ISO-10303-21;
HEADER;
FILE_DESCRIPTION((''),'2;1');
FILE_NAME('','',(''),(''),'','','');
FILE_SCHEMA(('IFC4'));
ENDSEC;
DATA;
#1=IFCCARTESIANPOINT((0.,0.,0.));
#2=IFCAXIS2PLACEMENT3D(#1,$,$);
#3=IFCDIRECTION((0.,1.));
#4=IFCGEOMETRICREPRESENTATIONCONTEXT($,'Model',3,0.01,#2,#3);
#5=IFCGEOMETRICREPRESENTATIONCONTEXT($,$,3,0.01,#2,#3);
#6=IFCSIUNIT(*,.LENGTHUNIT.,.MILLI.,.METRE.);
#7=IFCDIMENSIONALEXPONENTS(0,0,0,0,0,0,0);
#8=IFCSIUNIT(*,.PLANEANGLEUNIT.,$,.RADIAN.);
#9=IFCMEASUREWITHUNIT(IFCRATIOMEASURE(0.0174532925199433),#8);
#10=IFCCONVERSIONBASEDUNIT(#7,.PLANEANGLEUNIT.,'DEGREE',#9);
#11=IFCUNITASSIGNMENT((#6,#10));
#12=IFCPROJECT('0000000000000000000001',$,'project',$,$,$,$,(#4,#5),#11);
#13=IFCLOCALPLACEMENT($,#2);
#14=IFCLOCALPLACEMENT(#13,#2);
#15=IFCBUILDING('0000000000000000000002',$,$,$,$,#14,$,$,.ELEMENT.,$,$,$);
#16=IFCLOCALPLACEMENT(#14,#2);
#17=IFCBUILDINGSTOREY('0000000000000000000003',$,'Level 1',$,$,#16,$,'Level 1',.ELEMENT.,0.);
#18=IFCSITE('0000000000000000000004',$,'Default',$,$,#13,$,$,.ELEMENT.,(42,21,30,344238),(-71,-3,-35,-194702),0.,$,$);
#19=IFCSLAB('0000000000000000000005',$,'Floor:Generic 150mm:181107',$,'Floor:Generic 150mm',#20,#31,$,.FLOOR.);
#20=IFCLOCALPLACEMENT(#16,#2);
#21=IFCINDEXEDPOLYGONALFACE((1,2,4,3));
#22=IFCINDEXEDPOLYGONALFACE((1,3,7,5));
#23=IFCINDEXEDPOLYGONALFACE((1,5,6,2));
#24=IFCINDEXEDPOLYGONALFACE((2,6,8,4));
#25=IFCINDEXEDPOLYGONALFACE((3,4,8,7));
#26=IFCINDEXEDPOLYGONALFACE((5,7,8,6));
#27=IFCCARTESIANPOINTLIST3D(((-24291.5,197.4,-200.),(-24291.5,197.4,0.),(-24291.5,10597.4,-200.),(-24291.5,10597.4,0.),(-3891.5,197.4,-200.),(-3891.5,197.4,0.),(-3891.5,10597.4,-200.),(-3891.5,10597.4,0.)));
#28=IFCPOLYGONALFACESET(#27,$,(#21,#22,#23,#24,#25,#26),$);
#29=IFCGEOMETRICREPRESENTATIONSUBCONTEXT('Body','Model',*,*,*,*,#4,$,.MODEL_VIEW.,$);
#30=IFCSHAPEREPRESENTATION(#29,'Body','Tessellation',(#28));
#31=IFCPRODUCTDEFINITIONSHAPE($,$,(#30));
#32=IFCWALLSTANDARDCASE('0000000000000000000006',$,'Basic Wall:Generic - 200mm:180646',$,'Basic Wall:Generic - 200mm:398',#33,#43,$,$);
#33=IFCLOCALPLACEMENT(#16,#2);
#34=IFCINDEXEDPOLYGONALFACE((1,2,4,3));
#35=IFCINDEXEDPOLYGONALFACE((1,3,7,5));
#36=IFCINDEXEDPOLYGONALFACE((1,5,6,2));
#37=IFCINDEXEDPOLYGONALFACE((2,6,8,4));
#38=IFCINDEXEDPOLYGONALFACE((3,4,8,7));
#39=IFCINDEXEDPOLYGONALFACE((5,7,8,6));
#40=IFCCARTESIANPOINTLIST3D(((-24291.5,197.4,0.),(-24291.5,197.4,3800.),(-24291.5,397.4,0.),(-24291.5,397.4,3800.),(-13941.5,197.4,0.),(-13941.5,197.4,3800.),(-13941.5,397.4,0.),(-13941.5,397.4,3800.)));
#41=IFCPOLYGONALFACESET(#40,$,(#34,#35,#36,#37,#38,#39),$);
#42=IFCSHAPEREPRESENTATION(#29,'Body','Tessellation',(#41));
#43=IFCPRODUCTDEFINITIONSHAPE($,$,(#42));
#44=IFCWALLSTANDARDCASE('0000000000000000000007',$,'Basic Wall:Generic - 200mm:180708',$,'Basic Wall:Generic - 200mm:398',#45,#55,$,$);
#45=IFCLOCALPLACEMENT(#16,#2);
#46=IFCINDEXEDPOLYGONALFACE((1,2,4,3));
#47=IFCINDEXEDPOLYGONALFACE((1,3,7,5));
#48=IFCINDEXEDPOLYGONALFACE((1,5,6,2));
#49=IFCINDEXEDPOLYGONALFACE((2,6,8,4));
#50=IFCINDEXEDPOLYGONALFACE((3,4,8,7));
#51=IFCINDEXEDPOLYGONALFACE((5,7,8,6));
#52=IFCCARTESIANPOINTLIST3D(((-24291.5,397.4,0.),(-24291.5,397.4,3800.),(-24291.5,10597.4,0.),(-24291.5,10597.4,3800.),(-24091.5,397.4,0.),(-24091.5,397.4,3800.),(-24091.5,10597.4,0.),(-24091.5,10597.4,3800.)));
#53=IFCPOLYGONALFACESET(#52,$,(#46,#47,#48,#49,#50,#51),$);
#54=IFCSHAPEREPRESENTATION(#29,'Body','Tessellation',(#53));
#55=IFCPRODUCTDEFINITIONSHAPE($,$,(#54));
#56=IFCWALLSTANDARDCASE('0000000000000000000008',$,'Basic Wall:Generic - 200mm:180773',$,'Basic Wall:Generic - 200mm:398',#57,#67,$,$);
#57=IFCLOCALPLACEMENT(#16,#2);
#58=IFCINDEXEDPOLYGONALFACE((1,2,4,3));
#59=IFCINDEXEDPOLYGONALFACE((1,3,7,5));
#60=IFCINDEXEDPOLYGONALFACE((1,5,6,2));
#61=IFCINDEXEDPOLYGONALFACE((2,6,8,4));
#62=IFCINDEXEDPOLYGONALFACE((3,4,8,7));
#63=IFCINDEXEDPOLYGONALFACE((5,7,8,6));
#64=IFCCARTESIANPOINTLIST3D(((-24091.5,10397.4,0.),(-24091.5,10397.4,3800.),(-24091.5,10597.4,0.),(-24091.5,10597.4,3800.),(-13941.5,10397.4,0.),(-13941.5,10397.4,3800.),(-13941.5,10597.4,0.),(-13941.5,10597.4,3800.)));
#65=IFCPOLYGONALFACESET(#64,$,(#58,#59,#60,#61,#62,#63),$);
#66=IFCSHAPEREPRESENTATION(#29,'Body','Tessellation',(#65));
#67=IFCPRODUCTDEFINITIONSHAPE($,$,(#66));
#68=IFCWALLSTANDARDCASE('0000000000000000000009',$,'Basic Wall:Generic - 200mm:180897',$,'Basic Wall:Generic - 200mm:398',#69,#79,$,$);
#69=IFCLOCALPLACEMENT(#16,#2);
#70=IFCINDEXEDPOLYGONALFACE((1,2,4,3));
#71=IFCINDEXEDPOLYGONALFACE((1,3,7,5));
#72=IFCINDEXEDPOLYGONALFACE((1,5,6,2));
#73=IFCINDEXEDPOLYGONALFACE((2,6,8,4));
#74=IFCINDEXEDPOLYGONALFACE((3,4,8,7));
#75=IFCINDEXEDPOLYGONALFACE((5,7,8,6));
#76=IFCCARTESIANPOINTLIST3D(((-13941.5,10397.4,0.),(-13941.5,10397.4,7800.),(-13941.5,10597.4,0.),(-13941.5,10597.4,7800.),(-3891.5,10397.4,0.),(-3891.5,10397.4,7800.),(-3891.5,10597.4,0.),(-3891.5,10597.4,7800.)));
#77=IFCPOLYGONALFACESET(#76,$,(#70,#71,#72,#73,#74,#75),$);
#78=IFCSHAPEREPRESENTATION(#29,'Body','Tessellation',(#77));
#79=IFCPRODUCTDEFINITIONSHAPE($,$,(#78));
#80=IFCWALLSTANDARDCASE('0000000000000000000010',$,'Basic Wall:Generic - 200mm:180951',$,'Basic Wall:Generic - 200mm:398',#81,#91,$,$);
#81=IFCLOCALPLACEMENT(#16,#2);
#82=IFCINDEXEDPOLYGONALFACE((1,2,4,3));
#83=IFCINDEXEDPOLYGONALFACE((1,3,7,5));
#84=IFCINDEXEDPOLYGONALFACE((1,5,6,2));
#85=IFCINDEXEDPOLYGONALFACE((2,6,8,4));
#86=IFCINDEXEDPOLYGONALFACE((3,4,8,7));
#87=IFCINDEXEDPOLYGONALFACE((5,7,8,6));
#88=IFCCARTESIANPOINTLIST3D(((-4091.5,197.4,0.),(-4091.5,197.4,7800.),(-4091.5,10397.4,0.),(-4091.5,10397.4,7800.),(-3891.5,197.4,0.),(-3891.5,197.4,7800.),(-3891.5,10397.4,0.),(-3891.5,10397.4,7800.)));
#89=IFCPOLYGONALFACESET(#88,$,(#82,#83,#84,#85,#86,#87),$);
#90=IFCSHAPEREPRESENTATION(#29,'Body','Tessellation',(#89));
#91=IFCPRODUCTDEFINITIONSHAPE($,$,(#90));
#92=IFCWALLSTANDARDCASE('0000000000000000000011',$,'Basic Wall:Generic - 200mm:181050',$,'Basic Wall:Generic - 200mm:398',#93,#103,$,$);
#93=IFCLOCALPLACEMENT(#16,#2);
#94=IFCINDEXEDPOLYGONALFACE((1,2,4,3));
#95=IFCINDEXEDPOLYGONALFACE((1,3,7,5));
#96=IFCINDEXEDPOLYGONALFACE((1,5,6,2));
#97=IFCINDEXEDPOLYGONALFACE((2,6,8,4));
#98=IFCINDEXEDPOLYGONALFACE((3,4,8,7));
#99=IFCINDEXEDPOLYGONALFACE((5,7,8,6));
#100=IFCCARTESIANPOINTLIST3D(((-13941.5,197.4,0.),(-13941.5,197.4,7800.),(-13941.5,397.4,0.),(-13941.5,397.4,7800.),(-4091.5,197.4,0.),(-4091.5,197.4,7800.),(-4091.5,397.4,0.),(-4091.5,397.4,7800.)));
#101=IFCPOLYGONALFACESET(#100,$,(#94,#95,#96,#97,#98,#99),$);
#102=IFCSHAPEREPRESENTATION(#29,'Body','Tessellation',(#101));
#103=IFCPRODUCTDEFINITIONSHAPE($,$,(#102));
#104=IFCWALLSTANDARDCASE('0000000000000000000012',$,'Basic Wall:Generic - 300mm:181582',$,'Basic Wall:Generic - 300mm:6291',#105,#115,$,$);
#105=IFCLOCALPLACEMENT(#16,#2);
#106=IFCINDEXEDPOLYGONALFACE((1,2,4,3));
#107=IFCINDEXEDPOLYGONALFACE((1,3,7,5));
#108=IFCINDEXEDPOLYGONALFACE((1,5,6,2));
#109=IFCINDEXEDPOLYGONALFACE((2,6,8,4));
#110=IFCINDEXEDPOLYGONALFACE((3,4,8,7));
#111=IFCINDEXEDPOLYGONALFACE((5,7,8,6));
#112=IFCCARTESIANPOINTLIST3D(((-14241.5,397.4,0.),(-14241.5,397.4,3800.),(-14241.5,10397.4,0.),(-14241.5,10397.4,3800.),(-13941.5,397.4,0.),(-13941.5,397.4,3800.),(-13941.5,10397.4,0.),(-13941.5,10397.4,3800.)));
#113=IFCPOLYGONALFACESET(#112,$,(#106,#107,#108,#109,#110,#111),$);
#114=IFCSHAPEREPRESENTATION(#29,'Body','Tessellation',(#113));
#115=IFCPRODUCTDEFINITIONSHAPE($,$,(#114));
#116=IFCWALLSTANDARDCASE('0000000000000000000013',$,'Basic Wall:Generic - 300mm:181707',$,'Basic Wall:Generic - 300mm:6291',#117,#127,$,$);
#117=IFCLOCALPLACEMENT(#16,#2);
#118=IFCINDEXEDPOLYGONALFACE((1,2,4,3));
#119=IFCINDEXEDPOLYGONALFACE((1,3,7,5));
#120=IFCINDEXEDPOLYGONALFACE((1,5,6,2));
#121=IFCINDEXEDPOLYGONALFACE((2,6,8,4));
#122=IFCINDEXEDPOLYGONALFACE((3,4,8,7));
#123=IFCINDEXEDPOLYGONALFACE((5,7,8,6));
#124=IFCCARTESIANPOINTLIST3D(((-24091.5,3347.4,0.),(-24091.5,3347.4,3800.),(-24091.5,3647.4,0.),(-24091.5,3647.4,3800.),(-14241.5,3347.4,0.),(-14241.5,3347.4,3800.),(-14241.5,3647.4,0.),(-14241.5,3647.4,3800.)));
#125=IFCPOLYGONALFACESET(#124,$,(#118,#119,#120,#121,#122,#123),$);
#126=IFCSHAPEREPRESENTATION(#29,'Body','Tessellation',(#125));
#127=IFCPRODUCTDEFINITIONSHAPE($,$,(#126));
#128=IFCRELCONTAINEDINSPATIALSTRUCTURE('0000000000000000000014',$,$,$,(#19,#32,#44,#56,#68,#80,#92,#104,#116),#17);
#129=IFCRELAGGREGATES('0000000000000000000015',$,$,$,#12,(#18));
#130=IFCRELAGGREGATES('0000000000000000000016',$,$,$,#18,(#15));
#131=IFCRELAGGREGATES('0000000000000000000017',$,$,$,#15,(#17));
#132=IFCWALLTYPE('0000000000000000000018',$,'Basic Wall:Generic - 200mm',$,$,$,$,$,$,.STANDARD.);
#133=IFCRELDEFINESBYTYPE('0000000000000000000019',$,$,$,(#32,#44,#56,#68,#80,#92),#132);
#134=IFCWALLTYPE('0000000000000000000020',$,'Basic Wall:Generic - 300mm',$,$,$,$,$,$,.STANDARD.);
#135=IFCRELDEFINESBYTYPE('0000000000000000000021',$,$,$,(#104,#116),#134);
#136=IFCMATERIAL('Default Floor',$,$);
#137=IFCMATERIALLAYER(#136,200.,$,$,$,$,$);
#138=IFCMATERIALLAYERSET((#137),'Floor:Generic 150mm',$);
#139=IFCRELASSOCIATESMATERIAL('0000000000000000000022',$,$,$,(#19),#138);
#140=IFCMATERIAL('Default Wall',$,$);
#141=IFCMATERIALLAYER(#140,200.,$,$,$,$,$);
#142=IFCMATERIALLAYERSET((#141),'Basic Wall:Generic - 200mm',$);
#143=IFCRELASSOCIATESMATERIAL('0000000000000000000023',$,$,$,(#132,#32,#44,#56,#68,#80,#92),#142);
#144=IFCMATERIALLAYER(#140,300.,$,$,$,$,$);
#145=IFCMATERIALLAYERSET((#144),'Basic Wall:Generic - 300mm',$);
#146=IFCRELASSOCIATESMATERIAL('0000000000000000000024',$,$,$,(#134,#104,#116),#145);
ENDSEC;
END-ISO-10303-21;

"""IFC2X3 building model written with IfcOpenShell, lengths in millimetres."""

from ifc_helpers import new_model, entity, si_unit, converted_unit, direction, frame, frame_2d, origin, place, context, subcontext, project, spatial, rectangle, extrude, material, layer, layer_set, layer_usage, type_object, element, save


model = new_model("IFC2X3")

# Units and contexts
model_context = context("Model", 3, precision=0.01, world=origin(), true_north=direction((0.0, 1.0)))
context_of_model = context(None, 3, precision=0.01, world=origin(), true_north=direction((0.0, 1.0)))
body_context = subcontext(model_context, "Body", "Model", "MODEL_VIEW")
ifc_project = project(units=[si_unit("LENGTHUNIT", "METRE", prefix="MILLI"), converted_unit("PLANEANGLEUNIT", "DEGREE", entity("IfcRatioMeasure", 0.0174532925199433), si_unit("PLANEANGLEUNIT", "RADIAN"), dimensions=[0, 0, 0, 0, 0, 0, 0])], contexts=[model_context, context_of_model])

# Site, building, storey
site_placement = place(None, origin())
site = spatial("IfcSite", under=ifc_project, at=site_placement, Name="Default", CompositionType="ELEMENT", RefLatitude=(42, 21, 30, 344238), RefLongitude=(-71, -3, -35, -194702), RefElevation=0.0)
building_placement = place(site_placement, origin())
building = spatial("IfcBuilding", under=site, at=building_placement, CompositionType="ELEMENT")
storey_placement = place(building_placement, origin())
storey = spatial("IfcBuildingStorey", under=building, at=storey_placement, Name="Level 1", LongName="Level 1", CompositionType="ELEMENT", Elevation=0.0)

# Slab
ifc_material_1 = material(Name="Default Floor")
ifc_layer_1 = layer(ifc_material_1, 200.0)
ifc_layer_set_1 = layer_set([ifc_layer_1], Name="Floor:Generic 150mm")
ifc_layer_usage_1 = layer_usage(ifc_layer_set_1, "AXIS3", "POSITIVE", 0.0)
slab_placement = place(storey_placement, origin())
element("IfcSlab", 1, at=slab_placement, inside=storey, material=ifc_layer_usage_1, Name="Floor:Generic 150mm:181107", ObjectType="Floor:Generic 150mm", PredefinedType="FLOOR", context=body_context, shape_type="SweptSolid", body=[
    extrude(rectangle(XDim=10400.0, YDim=20400.0, at=frame_2d((0.0, 0.0), x_axis=(1.0, 0.0))), frame((-14091.5, 5397.4, 0.0), z_axis=(0.0, 0.0, -1.0), x_axis=(0.0, 1.0, 0.0)), (0.0, 0.0, 1.0), 200.0),
])

# Walls
ifc_material_2 = material(Name="Default Wall")
ifc_layer_2 = layer(ifc_material_2, 200.0)
ifc_layer_set_2 = layer_set([ifc_layer_2], Name="Basic Wall:Generic - 200mm")
ifc_layer_usage_2 = layer_usage(ifc_layer_set_2, "AXIS2", "NEGATIVE", 100.0)
wall_type_1 = type_object("IfcWallType", Name="Basic Wall:Generic - 200mm", PredefinedType="STANDARD", material=ifc_layer_set_2)
wall_1_placement = place(storey_placement, frame((-13941.5, 297.4, 0.0), z_axis=(0.0, 0.0, 1.0), x_axis=(-1.0, 0.0, 0.0)))
element("IfcWallStandardCase", 2, at=wall_1_placement, inside=storey, type_object=wall_type_1, material=ifc_layer_usage_2, Name="Basic Wall:Generic - 200mm:180646", ObjectType="Basic Wall:Generic - 200mm:398", context=body_context, shape_type="SweptSolid", body=[
    extrude(rectangle(XDim=10350.0, YDim=200.0, at=frame_2d((5175.0, 0.0), x_axis=(-1.0, 0.0))), origin(), (0.0, 0.0, 1.0), 3800.0),
])
ifc_layer_usage_3 = layer_usage(ifc_layer_set_2, "AXIS2", "NEGATIVE", 100.0)
wall_2_placement = place(storey_placement, frame((-24191.5, 397.4, 0.0), z_axis=(0.0, 0.0, 1.0), x_axis=(0.0, 1.0, 0.0)))
element("IfcWallStandardCase", 3, at=wall_2_placement, inside=storey, type_object=wall_type_1, material=ifc_layer_usage_3, Name="Basic Wall:Generic - 200mm:180708", ObjectType="Basic Wall:Generic - 200mm:398", context=body_context, shape_type="SweptSolid", body=[
    extrude(rectangle(XDim=10200.0, YDim=200.0, at=frame_2d((5100.0, 0.0), x_axis=(-1.0, 0.0))), origin(), (0.0, 0.0, 1.0), 3800.0),
])
ifc_layer_usage_4 = layer_usage(ifc_layer_set_2, "AXIS2", "NEGATIVE", 100.0)
wall_3_placement = place(storey_placement, frame((-24091.5, 10497.4, 0.0)))
element("IfcWallStandardCase", 4, at=wall_3_placement, inside=storey, type_object=wall_type_1, material=ifc_layer_usage_4, Name="Basic Wall:Generic - 200mm:180773", ObjectType="Basic Wall:Generic - 200mm:398", context=body_context, shape_type="SweptSolid", body=[
    extrude(rectangle(XDim=10150.0, YDim=200.0, at=frame_2d((5075.0, 0.0), x_axis=(-1.0, 0.0))), origin(), (0.0, 0.0, 1.0), 3800.0),
])
ifc_layer_usage_5 = layer_usage(ifc_layer_set_2, "AXIS2", "NEGATIVE", 100.0)
wall_4_placement = place(storey_placement, frame((-13941.5, 10497.4, 0.0)))
element("IfcWallStandardCase", 5, at=wall_4_placement, inside=storey, type_object=wall_type_1, material=ifc_layer_usage_5, Name="Basic Wall:Generic - 200mm:180897", ObjectType="Basic Wall:Generic - 200mm:398", context=body_context, shape_type="SweptSolid", body=[
    extrude(rectangle(XDim=10050.0, YDim=200.0, at=frame_2d((5025.0, 0.0), x_axis=(-1.0, 0.0))), origin(), (0.0, 0.0, 1.0), 7800.0),
])
ifc_layer_usage_6 = layer_usage(ifc_layer_set_2, "AXIS2", "NEGATIVE", 100.0)
wall_5_placement = place(storey_placement, frame((-3991.5, 10397.4, 0.0), z_axis=(0.0, 0.0, 1.0), x_axis=(0.0, -1.0, 0.0)))
element("IfcWallStandardCase", 6, at=wall_5_placement, inside=storey, type_object=wall_type_1, material=ifc_layer_usage_6, Name="Basic Wall:Generic - 200mm:180951", ObjectType="Basic Wall:Generic - 200mm:398", context=body_context, shape_type="SweptSolid", body=[
    extrude(rectangle(XDim=10200.0, YDim=200.0, at=frame_2d((5100.0, 0.0), x_axis=(-1.0, 0.0))), origin(), (0.0, 0.0, 1.0), 7800.0),
])
ifc_layer_usage_7 = layer_usage(ifc_layer_set_2, "AXIS2", "NEGATIVE", 100.0)
wall_6_placement = place(storey_placement, frame((-4091.5, 297.4, 0.0), z_axis=(0.0, 0.0, 1.0), x_axis=(-1.0, 0.0, 0.0)))
element("IfcWallStandardCase", 7, at=wall_6_placement, inside=storey, type_object=wall_type_1, material=ifc_layer_usage_7, Name="Basic Wall:Generic - 200mm:181050", ObjectType="Basic Wall:Generic - 200mm:398", context=body_context, shape_type="SweptSolid", body=[
    extrude(rectangle(XDim=9850.0, YDim=200.0, at=frame_2d((4925.0, 0.0), x_axis=(-1.0, 0.0))), origin(), (0.0, 0.0, 1.0), 7800.0),
])
ifc_layer_3 = layer(ifc_material_2, 300.0)
ifc_layer_set_3 = layer_set([ifc_layer_3], Name="Basic Wall:Generic - 300mm")
ifc_layer_usage_8 = layer_usage(ifc_layer_set_3, "AXIS2", "NEGATIVE", 150.0)
wall_type_2 = type_object("IfcWallType", Name="Basic Wall:Generic - 300mm", PredefinedType="STANDARD", material=ifc_layer_set_3)
wall_7_placement = place(storey_placement, frame((-14091.5, 10397.4, 0.0), z_axis=(0.0, 0.0, 1.0), x_axis=(0.0, -1.0, 0.0)))
element("IfcWallStandardCase", 8, at=wall_7_placement, inside=storey, type_object=wall_type_2, material=ifc_layer_usage_8, Name="Basic Wall:Generic - 300mm:181582", ObjectType="Basic Wall:Generic - 300mm:6291", context=body_context, shape_type="SweptSolid", body=[
    extrude(rectangle(XDim=10000.0, YDim=300.0, at=frame_2d((5000.0, 0.0), x_axis=(-1.0, 0.0))), origin(), (0.0, 0.0, 1.0), 3800.0),
])
ifc_layer_usage_9 = layer_usage(ifc_layer_set_3, "AXIS2", "NEGATIVE", 150.0)
wall_8_placement = place(storey_placement, frame((-24091.5, 3497.4, 0.0)))
element("IfcWallStandardCase", 9, at=wall_8_placement, inside=storey, type_object=wall_type_2, material=ifc_layer_usage_9, Name="Basic Wall:Generic - 300mm:181707", ObjectType="Basic Wall:Generic - 300mm:6291", context=body_context, shape_type="SweptSolid", body=[
    extrude(rectangle(XDim=9850.0, YDim=300.0, at=frame_2d((4925.0, 0.0), x_axis=(-1.0, 0.0))), origin(), (0.0, 0.0, 1.0), 3800.0),
])

save(model, "model.ifc")
